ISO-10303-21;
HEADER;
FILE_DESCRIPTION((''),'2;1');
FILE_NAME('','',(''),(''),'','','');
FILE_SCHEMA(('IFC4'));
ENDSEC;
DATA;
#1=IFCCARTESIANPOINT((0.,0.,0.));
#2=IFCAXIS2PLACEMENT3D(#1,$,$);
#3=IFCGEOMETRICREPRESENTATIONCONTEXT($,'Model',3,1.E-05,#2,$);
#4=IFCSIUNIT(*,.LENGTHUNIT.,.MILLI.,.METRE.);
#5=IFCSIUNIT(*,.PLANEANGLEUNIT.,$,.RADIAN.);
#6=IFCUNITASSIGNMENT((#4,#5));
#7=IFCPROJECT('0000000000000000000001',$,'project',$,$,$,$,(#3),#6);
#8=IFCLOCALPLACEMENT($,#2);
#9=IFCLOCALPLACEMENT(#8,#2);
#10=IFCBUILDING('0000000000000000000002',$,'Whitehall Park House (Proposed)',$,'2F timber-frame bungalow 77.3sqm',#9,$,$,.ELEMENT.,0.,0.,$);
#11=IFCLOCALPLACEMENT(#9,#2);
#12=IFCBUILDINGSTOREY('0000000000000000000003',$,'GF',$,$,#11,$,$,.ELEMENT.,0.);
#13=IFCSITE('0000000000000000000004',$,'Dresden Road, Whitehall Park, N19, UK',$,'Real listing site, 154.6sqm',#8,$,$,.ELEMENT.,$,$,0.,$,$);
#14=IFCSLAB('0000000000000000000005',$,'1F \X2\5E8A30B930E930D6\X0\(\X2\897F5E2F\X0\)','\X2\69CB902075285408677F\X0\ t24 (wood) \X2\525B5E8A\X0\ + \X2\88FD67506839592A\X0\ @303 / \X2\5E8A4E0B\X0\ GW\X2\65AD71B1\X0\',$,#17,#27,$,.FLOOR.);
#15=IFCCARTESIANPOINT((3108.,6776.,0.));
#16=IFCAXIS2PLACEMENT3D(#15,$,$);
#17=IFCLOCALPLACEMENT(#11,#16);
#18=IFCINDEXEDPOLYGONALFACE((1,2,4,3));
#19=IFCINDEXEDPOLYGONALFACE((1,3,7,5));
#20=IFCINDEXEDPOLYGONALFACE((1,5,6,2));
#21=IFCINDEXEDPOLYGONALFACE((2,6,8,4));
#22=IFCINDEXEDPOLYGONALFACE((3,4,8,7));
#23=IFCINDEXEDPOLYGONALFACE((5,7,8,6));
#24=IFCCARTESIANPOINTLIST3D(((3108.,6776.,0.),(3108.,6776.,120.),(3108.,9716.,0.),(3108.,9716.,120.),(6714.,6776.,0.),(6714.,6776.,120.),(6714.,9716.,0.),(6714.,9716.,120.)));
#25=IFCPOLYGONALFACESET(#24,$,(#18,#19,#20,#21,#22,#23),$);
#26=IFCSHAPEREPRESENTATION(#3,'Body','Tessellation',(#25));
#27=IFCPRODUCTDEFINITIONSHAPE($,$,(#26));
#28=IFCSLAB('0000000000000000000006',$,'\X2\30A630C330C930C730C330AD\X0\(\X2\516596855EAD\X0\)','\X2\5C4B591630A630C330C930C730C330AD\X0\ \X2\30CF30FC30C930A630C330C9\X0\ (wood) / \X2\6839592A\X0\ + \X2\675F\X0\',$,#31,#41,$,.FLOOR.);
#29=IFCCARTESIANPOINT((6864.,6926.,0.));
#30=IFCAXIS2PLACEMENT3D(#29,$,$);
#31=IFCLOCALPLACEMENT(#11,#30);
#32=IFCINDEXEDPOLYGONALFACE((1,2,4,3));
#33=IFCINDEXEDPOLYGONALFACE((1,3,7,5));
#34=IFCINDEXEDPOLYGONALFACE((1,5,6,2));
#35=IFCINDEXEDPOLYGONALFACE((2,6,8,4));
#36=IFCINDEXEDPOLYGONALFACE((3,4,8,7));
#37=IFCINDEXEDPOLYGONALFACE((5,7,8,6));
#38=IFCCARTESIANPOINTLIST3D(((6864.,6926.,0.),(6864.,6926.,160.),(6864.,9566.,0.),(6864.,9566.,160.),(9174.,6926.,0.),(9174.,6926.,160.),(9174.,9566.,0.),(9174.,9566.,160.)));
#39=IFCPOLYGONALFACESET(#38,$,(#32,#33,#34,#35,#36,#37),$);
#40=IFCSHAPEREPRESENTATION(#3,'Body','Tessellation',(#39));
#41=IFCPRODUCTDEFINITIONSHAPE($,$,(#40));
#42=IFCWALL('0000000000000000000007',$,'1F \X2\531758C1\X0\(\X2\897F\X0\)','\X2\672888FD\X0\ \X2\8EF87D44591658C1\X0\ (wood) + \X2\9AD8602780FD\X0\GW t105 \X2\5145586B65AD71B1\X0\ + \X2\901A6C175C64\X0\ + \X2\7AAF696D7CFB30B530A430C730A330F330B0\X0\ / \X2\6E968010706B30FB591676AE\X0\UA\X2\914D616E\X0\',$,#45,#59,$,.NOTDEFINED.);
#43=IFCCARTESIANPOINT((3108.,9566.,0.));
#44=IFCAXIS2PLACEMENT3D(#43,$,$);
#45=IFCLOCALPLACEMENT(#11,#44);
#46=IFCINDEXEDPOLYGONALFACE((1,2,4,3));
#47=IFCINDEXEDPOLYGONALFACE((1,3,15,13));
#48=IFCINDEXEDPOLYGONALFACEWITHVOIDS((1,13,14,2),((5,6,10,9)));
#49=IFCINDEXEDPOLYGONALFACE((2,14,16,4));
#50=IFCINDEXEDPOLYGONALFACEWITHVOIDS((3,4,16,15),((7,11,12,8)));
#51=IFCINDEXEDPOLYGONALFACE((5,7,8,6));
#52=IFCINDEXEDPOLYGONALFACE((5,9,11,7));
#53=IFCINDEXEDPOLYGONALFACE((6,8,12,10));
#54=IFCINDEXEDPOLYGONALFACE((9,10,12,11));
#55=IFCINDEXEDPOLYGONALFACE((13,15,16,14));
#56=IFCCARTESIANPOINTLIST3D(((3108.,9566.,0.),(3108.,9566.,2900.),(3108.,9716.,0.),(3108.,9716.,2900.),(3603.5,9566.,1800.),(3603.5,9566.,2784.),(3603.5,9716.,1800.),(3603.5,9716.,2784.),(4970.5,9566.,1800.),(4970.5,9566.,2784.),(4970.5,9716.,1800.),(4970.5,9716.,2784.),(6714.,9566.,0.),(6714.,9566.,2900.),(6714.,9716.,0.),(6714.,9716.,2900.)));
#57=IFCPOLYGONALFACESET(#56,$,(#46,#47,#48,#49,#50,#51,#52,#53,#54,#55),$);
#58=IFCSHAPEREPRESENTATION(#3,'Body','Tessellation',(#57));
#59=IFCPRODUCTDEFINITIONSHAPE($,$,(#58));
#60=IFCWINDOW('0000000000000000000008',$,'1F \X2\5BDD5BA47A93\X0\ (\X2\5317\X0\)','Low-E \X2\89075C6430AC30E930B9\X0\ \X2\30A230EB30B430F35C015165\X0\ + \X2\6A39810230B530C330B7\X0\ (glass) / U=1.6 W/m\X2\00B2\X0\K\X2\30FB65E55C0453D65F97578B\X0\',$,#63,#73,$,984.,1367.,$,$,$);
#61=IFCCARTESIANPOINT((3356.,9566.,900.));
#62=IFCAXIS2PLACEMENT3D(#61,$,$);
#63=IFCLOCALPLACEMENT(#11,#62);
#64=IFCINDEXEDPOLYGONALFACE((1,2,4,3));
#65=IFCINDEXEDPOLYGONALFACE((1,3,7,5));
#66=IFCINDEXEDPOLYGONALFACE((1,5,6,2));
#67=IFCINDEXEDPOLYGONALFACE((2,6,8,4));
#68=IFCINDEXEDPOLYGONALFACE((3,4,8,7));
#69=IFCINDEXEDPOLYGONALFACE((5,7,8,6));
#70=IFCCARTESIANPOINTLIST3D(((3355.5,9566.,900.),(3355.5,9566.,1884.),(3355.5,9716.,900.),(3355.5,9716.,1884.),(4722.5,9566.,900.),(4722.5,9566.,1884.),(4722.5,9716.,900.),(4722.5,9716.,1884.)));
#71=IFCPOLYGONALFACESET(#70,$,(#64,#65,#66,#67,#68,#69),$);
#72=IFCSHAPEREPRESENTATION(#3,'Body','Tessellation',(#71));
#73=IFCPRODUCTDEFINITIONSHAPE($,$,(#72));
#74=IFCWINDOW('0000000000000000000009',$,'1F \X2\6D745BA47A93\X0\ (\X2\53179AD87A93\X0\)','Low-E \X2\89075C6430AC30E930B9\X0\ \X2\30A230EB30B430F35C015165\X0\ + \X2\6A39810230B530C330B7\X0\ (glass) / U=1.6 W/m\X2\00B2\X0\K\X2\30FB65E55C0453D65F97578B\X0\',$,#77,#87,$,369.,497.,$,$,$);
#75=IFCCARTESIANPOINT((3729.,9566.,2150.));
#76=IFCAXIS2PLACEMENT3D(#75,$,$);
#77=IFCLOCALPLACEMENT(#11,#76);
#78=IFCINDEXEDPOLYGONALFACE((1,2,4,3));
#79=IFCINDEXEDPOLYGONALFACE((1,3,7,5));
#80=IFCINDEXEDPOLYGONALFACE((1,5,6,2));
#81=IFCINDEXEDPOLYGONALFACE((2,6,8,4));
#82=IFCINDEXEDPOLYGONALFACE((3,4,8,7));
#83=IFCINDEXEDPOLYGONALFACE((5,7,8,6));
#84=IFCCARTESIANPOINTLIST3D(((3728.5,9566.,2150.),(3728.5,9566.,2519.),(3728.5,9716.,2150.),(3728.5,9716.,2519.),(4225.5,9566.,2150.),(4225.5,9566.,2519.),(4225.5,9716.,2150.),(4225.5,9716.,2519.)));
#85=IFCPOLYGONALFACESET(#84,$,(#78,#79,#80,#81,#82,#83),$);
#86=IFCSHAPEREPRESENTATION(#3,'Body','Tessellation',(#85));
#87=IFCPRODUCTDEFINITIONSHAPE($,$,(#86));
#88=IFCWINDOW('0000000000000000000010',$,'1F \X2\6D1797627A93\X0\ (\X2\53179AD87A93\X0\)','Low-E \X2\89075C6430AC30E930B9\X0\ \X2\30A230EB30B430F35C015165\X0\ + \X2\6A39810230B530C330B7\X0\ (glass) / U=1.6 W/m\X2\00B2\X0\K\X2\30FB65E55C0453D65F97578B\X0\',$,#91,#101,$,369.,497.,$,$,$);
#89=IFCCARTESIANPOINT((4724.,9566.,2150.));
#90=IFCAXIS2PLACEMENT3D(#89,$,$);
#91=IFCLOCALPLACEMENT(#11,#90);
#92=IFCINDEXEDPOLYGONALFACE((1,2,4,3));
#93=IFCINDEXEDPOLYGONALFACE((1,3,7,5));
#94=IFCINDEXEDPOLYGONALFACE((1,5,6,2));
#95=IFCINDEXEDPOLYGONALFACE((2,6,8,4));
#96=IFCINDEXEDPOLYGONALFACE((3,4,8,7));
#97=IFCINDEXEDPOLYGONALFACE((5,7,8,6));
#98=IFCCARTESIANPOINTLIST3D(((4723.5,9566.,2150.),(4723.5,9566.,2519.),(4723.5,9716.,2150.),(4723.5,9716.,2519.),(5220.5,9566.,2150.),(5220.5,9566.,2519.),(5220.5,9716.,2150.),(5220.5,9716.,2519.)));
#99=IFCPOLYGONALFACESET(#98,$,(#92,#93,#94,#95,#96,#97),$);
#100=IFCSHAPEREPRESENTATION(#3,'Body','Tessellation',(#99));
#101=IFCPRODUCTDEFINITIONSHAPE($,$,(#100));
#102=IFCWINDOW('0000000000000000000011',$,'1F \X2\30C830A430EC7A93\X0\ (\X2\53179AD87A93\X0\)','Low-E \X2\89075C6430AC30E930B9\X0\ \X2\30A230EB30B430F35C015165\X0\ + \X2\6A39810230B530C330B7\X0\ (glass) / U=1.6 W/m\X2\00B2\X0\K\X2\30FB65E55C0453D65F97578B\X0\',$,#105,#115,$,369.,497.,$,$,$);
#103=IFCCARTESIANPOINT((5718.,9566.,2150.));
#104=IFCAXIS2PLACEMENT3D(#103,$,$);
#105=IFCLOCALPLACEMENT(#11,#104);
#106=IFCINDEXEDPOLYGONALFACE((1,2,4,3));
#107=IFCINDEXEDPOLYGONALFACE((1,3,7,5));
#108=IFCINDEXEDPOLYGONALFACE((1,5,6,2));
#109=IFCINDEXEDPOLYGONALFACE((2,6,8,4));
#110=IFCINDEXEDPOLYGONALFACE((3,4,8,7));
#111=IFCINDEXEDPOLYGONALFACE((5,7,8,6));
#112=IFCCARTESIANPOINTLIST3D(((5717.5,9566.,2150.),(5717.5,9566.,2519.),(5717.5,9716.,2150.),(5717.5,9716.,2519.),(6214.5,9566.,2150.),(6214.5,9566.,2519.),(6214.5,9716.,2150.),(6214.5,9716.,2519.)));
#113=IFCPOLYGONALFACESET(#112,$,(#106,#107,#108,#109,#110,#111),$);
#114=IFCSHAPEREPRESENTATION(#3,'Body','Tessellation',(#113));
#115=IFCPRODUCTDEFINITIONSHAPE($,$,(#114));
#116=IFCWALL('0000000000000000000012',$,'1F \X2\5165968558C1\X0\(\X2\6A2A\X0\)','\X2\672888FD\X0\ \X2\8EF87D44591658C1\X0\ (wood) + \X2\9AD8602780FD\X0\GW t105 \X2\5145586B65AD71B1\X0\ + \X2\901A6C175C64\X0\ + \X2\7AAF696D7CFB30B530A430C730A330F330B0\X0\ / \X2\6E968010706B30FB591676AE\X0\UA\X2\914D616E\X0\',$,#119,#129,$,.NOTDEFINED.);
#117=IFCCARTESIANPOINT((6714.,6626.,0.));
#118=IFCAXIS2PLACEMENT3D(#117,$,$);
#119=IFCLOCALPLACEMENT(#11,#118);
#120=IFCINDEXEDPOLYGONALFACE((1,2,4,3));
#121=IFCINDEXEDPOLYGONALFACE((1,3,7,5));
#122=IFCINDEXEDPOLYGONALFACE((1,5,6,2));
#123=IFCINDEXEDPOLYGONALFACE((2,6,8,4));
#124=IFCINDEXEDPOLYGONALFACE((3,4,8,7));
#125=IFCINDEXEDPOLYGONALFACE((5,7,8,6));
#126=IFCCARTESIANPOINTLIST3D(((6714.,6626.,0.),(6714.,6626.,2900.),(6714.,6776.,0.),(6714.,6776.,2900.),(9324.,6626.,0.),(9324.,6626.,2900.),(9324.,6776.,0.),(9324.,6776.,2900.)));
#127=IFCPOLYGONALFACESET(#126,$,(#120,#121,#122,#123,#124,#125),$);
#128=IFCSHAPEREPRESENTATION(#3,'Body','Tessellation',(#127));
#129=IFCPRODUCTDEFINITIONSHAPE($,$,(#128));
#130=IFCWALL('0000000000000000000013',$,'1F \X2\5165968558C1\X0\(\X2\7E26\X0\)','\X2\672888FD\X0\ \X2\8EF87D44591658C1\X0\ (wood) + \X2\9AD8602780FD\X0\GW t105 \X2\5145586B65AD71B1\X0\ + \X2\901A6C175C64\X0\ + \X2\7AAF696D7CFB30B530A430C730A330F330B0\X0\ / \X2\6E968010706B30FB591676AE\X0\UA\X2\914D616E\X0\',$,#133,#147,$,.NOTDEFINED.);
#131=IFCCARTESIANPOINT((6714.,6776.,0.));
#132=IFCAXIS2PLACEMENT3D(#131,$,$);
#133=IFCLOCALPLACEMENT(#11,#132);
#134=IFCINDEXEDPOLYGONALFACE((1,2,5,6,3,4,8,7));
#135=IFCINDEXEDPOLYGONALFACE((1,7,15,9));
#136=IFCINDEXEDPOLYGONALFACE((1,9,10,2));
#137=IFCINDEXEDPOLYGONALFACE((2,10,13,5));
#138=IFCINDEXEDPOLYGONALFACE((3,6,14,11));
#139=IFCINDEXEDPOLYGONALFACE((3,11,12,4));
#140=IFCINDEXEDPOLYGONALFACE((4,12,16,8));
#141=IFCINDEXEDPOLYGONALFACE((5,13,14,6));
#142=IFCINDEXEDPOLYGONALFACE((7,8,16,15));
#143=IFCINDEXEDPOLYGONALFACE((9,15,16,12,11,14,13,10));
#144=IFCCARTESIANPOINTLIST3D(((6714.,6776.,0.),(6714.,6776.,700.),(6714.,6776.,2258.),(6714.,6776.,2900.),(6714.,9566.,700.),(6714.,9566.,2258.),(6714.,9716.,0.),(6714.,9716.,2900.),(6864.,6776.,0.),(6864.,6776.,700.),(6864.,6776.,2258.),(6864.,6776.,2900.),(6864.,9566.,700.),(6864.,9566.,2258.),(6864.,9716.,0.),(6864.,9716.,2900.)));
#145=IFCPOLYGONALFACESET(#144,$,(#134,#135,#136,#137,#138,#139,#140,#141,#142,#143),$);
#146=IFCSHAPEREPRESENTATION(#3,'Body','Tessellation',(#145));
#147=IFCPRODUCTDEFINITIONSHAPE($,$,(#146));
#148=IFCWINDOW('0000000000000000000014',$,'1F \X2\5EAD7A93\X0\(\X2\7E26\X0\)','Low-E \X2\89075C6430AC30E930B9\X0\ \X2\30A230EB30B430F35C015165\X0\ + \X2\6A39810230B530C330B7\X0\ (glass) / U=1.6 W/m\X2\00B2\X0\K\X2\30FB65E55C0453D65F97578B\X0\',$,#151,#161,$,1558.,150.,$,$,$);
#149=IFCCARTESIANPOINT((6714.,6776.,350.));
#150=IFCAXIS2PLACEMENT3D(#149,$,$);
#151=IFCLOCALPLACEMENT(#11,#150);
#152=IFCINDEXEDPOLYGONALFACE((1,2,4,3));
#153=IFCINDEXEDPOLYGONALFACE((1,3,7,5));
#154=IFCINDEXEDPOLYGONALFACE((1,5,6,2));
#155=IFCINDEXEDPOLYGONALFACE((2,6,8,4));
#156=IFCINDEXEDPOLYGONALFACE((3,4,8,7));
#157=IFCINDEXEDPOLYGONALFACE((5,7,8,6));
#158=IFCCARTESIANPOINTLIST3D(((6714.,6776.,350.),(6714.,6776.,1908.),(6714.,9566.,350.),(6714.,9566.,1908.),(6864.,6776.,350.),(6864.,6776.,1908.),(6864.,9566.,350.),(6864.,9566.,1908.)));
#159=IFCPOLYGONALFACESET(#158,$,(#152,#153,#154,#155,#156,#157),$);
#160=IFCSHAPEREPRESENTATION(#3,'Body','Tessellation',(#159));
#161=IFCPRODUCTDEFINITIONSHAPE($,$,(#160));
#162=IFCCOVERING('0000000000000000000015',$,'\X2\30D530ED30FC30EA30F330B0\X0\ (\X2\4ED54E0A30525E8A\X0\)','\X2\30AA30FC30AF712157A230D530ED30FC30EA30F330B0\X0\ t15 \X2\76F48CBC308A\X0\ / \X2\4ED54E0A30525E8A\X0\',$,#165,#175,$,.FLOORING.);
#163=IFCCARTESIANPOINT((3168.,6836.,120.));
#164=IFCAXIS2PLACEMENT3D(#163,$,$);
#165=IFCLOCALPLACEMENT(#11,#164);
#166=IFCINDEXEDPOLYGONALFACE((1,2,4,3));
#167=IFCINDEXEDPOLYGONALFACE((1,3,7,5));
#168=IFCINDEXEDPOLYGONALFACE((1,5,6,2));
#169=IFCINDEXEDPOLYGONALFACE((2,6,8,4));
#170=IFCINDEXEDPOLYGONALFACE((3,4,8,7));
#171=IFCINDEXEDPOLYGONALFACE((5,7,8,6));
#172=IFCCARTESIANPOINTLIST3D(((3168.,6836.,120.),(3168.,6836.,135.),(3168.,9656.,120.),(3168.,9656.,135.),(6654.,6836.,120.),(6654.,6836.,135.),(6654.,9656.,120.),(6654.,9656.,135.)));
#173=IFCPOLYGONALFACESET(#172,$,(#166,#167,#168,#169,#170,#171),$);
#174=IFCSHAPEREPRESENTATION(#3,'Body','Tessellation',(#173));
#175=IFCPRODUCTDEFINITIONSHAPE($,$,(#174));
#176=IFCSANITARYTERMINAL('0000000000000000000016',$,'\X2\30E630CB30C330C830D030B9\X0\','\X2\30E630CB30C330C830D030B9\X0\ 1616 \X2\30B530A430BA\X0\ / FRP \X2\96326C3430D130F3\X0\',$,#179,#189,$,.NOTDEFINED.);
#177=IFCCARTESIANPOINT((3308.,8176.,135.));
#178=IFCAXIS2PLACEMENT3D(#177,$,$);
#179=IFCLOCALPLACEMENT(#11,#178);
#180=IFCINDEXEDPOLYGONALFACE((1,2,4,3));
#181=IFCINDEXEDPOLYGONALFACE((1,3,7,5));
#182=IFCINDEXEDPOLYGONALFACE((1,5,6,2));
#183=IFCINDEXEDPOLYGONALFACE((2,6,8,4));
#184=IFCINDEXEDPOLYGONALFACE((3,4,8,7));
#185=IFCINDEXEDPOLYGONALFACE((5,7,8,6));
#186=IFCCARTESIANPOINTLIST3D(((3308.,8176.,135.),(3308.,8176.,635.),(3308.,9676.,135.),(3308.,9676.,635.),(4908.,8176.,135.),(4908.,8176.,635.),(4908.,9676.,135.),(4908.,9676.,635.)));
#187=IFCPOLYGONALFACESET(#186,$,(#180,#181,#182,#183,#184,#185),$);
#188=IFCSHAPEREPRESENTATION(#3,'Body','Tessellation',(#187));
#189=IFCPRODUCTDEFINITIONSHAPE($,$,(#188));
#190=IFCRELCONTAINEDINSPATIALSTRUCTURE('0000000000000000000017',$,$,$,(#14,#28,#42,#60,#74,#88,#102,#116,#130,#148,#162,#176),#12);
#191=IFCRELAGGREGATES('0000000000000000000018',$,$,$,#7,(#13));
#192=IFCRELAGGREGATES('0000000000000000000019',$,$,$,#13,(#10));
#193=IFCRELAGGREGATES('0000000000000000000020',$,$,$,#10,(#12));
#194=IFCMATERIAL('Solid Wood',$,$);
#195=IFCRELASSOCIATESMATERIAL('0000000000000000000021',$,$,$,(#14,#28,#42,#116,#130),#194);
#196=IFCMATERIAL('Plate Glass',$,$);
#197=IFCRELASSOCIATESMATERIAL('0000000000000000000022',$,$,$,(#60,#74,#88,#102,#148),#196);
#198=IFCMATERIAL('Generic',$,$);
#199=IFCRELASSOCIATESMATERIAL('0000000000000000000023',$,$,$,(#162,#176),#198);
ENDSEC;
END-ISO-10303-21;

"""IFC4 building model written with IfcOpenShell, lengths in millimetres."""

from ifc_helpers import new_model, si_unit, frame, frame_2d, origin, place, context, project, spatial, rectangle, extrude, material, element, fill, save


model = new_model("IFC4")

# Units and contexts
model_context = context("Model", 3, precision=1e-05, world=origin())
ifc_project = project(units=[si_unit("LENGTHUNIT", "METRE", prefix="MILLI"), si_unit("PLANEANGLEUNIT", "RADIAN")], contexts=[model_context])

# Site, building, storey
site_placement = place(None, origin())
site = spatial("IfcSite", under=ifc_project, at=site_placement, Name="Dresden Road, Whitehall Park, N19, UK", ObjectType="Real listing site, 154.6sqm", CompositionType="ELEMENT", RefElevation=0.0)
building_placement = place(site_placement, origin())
building = spatial("IfcBuilding", under=site, at=building_placement, Name="Whitehall Park House (Proposed)", ObjectType="2F timber-frame bungalow 77.3sqm", CompositionType="ELEMENT", ElevationOfRefHeight=0.0, ElevationOfTerrain=0.0)
storey_placement = place(building_placement, origin())
storey = spatial("IfcBuildingStorey", under=building, at=storey_placement, Name="GF", CompositionType="ELEMENT", Elevation=0.0)

# Slabs
ifc_material_1 = material(Name="Solid Wood")
slab_1_placement = place(storey_placement, frame((3108.0, 6776.0, 0.0)))
element("IfcSlab", 1, at=slab_1_placement, inside=storey, material=ifc_material_1, Name="1F 床スラブ(西帯)", Description="構造用合板 t24 (wood) 剛床 + 製材根太 @303 / 床下 GW断熱", PredefinedType="FLOOR", context=model_context, shape_type="SweptSolid", body=[
    extrude(rectangle(XDim=3606.0, YDim=2940.0, at=frame_2d((1803.0, 1470.0))), frame((3108.0, 6776.0, 0.0)), (0.0, 0.0, 1.0), 120.0),
])
slab_2_placement = place(storey_placement, frame((6864.0, 6926.0, 0.0)))
element("IfcSlab", 2, at=slab_2_placement, inside=storey, material=ifc_material_1, Name="ウッドデッキ(入隅庭)", Description="屋外ウッドデッキ ハードウッド (wood) / 根太 + 束", PredefinedType="FLOOR", context=model_context, shape_type="SweptSolid", body=[
    extrude(rectangle(XDim=2310.0, YDim=2640.0, at=frame_2d((1155.0, 1320.0))), frame((6864.0, 6926.0, 0.0)), (0.0, 0.0, 1.0), 160.0),
])

# Wall, openings, windows
wall_1_placement = place(storey_placement, frame((3108.0, 9566.0, 0.0)))
wall_1 = element("IfcWall", 3, at=wall_1_placement, inside=storey, material=ifc_material_1, Name="1F 北壁(西)", Description="木製 軸組外壁 (wood) + 高性能GW t105 充填断熱 + 通気層 + 窯業系サイディング / 準耐火・外皮UA配慮", PredefinedType="NOTDEFINED", context=model_context, shape_type="SweptSolid", body=[
    extrude(rectangle(XDim=3606.0, YDim=150.0, at=frame_2d((1803.0, 75.0))), frame((3108.0, 9566.0, 0.0)), (0.0, 0.0, 1.0), 2900.0),
])
opening_1_placement = place(storey_placement, frame((3356.0, 9566.0, 900.0)))
opening_1 = element("IfcOpeningElement", 4, at=opening_1_placement, cuts=wall_1, PredefinedType="NOTDEFINED", context=model_context, shape_type="SweptSolid", body=[
    extrude(rectangle(XDim=1367.0, YDim=150.0, at=frame_2d((683.0, 75.0))), frame((3356.0, 9566.0, 900.0)), (0.0, 0.0, 1.0), 984.0),
])
opening_2_placement = place(storey_placement, frame((3729.0, 9566.0, 2150.0)))
opening_2 = element("IfcOpeningElement", 5, at=opening_2_placement, cuts=wall_1, PredefinedType="NOTDEFINED", context=model_context, shape_type="SweptSolid", body=[
    extrude(rectangle(XDim=497.0, YDim=150.0, at=frame_2d((248.0, 75.0))), frame((3729.0, 9566.0, 2150.0)), (0.0, 0.0, 1.0), 369.0),
])
opening_3_placement = place(storey_placement, frame((4724.0, 9566.0, 2150.0)))
opening_3 = element("IfcOpeningElement", 6, at=opening_3_placement, cuts=wall_1, PredefinedType="NOTDEFINED", context=model_context, shape_type="SweptSolid", body=[
    extrude(rectangle(XDim=497.0, YDim=150.0, at=frame_2d((248.0, 75.0))), frame((4724.0, 9566.0, 2150.0)), (0.0, 0.0, 1.0), 369.0),
])
opening_4_placement = place(storey_placement, frame((5718.0, 9566.0, 2150.0)))
opening_4 = element("IfcOpeningElement", 7, at=opening_4_placement, cuts=wall_1, PredefinedType="NOTDEFINED", context=model_context, shape_type="SweptSolid", body=[
    extrude(rectangle(XDim=497.0, YDim=150.0, at=frame_2d((248.0, 75.0))), frame((5718.0, 9566.0, 2150.0)), (0.0, 0.0, 1.0), 369.0),
])
ifc_material_2 = material(Name="Plate Glass")
window_1_placement = place(storey_placement, frame((3356.0, 9566.0, 900.0)))
window_1 = element("IfcWindow", 8, at=window_1_placement, inside=storey, material=ifc_material_2, Name="1F 寝室窓 (北)", Description="Low-E 複層ガラス アルゴン封入 + 樹脂サッシ (glass) / U=1.6 W/m²K・日射取得型", OverallHeight=984.0, OverallWidth=1367.0, context=model_context, shape_type="SweptSolid", body=[
    extrude(rectangle(XDim=1367.0, YDim=150.0, at=frame_2d((683.0, 75.0))), frame((3356.0, 9566.0, 900.0)), (0.0, 0.0, 1.0), 984.0),
])
fill(opening_1, window_1)
window_2_placement = place(storey_placement, frame((3729.0, 9566.0, 2150.0)))
window_2 = element("IfcWindow", 9, at=window_2_placement, inside=storey, material=ifc_material_2, Name="1F 浴室窓 (北高窓)", Description="Low-E 複層ガラス アルゴン封入 + 樹脂サッシ (glass) / U=1.6 W/m²K・日射取得型", OverallHeight=369.0, OverallWidth=497.0, context=model_context, shape_type="SweptSolid", body=[
    extrude(rectangle(XDim=497.0, YDim=150.0, at=frame_2d((248.0, 75.0))), frame((3729.0, 9566.0, 2150.0)), (0.0, 0.0, 1.0), 369.0),
])
fill(opening_2, window_2)
window_3_placement = place(storey_placement, frame((4724.0, 9566.0, 2150.0)))
window_3 = element("IfcWindow", 10, at=window_3_placement, inside=storey, material=ifc_material_2, Name="1F 洗面窓 (北高窓)", Description="Low-E 複層ガラス アルゴン封入 + 樹脂サッシ (glass) / U=1.6 W/m²K・日射取得型", OverallHeight=369.0, OverallWidth=497.0, context=model_context, shape_type="SweptSolid", body=[
    extrude(rectangle(XDim=497.0, YDim=150.0, at=frame_2d((248.0, 75.0))), frame((4724.0, 9566.0, 2150.0)), (0.0, 0.0, 1.0), 369.0),
])
fill(opening_3, window_3)
window_4_placement = place(storey_placement, frame((5718.0, 9566.0, 2150.0)))
window_4 = element("IfcWindow", 11, at=window_4_placement, inside=storey, material=ifc_material_2, Name="1F トイレ窓 (北高窓)", Description="Low-E 複層ガラス アルゴン封入 + 樹脂サッシ (glass) / U=1.6 W/m²K・日射取得型", OverallHeight=369.0, OverallWidth=497.0, context=model_context, shape_type="SweptSolid", body=[
    extrude(rectangle(XDim=497.0, YDim=150.0, at=frame_2d((248.0, 75.0))), frame((5718.0, 9566.0, 2150.0)), (0.0, 0.0, 1.0), 369.0),
])
fill(opening_4, window_4)

# Wall
wall_2_placement = place(storey_placement, frame((6714.0, 6626.0, 0.0)))
element("IfcWall", 12, at=wall_2_placement, inside=storey, material=ifc_material_1, Name="1F 入隅壁(横)", Description="木製 軸組外壁 (wood) + 高性能GW t105 充填断熱 + 通気層 + 窯業系サイディング / 準耐火・外皮UA配慮", PredefinedType="NOTDEFINED", context=model_context, shape_type="SweptSolid", body=[
    extrude(rectangle(XDim=2610.0, YDim=150.0, at=frame_2d((1305.0, 75.0))), frame((6714.0, 6626.0, 0.0)), (0.0, 0.0, 1.0), 2900.0),
])

# Wall, opening, window
wall_3_placement = place(storey_placement, frame((6714.0, 6776.0, 0.0)))
wall_3 = element("IfcWall", 13, at=wall_3_placement, inside=storey, material=ifc_material_1, Name="1F 入隅壁(縦)", Description="木製 軸組外壁 (wood) + 高性能GW t105 充填断熱 + 通気層 + 窯業系サイディング / 準耐火・外皮UA配慮", PredefinedType="NOTDEFINED", context=model_context, shape_type="SweptSolid", body=[
    extrude(rectangle(XDim=150.0, YDim=2940.0, at=frame_2d((75.0, 1470.0))), frame((6714.0, 6776.0, 0.0)), (0.0, 0.0, 1.0), 2900.0),
])
opening_5_placement = place(storey_placement, frame((6714.0, 6776.0, 350.0)))
opening_5 = element("IfcOpeningElement", 14, at=opening_5_placement, cuts=wall_3, PredefinedType="NOTDEFINED", context=model_context, shape_type="SweptSolid", body=[
    extrude(rectangle(XDim=150.0, YDim=2790.0, at=frame_2d((75.0, 1395.0))), frame((6714.0, 6776.0, 350.0)), (0.0, 0.0, 1.0), 1558.0),
])
window_5_placement = place(storey_placement, frame((6714.0, 6776.0, 350.0)))
window_5 = element("IfcWindow", 15, at=window_5_placement, inside=storey, material=ifc_material_2, Name="1F 庭窓(縦)", Description="Low-E 複層ガラス アルゴン封入 + 樹脂サッシ (glass) / U=1.6 W/m²K・日射取得型", OverallHeight=1558.0, OverallWidth=150.0, context=model_context, shape_type="SweptSolid", body=[
    extrude(rectangle(XDim=150.0, YDim=2790.0, at=frame_2d((75.0, 1395.0))), frame((6714.0, 6776.0, 350.0)), (0.0, 0.0, 1.0), 1558.0),
])
fill(opening_5, window_5)

# Covering
ifc_material_3 = material(Name="Generic")
covering_placement = place(storey_placement, frame((3168.0, 6836.0, 120.0)))
element("IfcCovering", 16, at=covering_placement, inside=storey, material=ifc_material_3, Name="フローリング (仕上げ床)", Description="オーク無垢フローリング t15 直貼り / 仕上げ床", PredefinedType="FLOORING", context=model_context, shape_type="SweptSolid", body=[
    extrude(rectangle(XDim=3486.0, YDim=2820.0, at=frame_2d((1743.0, 1410.0))), frame((3168.0, 6836.0, 120.0)), (0.0, 0.0, 1.0), 15.0),
])

# Sanitary terminal
sanitary_terminal_1_placement = place(storey_placement, frame((3308.0, 8176.0, 135.0)))
element("IfcSanitaryTerminal", 17, at=sanitary_terminal_1_placement, inside=storey, material=ifc_material_3, Name="ユニットバス", Description="ユニットバス 1616 サイズ / FRP 防水パン", PredefinedType="NOTDEFINED", context=model_context, shape_type="SweptSolid", body=[
    extrude(rectangle(XDim=1600.0, YDim=1500.0, at=frame_2d((800.0, 750.0))), frame((3308.0, 8176.0, 135.0)), (0.0, 0.0, 1.0), 500.0),
])

save(model, "model.ifc")
